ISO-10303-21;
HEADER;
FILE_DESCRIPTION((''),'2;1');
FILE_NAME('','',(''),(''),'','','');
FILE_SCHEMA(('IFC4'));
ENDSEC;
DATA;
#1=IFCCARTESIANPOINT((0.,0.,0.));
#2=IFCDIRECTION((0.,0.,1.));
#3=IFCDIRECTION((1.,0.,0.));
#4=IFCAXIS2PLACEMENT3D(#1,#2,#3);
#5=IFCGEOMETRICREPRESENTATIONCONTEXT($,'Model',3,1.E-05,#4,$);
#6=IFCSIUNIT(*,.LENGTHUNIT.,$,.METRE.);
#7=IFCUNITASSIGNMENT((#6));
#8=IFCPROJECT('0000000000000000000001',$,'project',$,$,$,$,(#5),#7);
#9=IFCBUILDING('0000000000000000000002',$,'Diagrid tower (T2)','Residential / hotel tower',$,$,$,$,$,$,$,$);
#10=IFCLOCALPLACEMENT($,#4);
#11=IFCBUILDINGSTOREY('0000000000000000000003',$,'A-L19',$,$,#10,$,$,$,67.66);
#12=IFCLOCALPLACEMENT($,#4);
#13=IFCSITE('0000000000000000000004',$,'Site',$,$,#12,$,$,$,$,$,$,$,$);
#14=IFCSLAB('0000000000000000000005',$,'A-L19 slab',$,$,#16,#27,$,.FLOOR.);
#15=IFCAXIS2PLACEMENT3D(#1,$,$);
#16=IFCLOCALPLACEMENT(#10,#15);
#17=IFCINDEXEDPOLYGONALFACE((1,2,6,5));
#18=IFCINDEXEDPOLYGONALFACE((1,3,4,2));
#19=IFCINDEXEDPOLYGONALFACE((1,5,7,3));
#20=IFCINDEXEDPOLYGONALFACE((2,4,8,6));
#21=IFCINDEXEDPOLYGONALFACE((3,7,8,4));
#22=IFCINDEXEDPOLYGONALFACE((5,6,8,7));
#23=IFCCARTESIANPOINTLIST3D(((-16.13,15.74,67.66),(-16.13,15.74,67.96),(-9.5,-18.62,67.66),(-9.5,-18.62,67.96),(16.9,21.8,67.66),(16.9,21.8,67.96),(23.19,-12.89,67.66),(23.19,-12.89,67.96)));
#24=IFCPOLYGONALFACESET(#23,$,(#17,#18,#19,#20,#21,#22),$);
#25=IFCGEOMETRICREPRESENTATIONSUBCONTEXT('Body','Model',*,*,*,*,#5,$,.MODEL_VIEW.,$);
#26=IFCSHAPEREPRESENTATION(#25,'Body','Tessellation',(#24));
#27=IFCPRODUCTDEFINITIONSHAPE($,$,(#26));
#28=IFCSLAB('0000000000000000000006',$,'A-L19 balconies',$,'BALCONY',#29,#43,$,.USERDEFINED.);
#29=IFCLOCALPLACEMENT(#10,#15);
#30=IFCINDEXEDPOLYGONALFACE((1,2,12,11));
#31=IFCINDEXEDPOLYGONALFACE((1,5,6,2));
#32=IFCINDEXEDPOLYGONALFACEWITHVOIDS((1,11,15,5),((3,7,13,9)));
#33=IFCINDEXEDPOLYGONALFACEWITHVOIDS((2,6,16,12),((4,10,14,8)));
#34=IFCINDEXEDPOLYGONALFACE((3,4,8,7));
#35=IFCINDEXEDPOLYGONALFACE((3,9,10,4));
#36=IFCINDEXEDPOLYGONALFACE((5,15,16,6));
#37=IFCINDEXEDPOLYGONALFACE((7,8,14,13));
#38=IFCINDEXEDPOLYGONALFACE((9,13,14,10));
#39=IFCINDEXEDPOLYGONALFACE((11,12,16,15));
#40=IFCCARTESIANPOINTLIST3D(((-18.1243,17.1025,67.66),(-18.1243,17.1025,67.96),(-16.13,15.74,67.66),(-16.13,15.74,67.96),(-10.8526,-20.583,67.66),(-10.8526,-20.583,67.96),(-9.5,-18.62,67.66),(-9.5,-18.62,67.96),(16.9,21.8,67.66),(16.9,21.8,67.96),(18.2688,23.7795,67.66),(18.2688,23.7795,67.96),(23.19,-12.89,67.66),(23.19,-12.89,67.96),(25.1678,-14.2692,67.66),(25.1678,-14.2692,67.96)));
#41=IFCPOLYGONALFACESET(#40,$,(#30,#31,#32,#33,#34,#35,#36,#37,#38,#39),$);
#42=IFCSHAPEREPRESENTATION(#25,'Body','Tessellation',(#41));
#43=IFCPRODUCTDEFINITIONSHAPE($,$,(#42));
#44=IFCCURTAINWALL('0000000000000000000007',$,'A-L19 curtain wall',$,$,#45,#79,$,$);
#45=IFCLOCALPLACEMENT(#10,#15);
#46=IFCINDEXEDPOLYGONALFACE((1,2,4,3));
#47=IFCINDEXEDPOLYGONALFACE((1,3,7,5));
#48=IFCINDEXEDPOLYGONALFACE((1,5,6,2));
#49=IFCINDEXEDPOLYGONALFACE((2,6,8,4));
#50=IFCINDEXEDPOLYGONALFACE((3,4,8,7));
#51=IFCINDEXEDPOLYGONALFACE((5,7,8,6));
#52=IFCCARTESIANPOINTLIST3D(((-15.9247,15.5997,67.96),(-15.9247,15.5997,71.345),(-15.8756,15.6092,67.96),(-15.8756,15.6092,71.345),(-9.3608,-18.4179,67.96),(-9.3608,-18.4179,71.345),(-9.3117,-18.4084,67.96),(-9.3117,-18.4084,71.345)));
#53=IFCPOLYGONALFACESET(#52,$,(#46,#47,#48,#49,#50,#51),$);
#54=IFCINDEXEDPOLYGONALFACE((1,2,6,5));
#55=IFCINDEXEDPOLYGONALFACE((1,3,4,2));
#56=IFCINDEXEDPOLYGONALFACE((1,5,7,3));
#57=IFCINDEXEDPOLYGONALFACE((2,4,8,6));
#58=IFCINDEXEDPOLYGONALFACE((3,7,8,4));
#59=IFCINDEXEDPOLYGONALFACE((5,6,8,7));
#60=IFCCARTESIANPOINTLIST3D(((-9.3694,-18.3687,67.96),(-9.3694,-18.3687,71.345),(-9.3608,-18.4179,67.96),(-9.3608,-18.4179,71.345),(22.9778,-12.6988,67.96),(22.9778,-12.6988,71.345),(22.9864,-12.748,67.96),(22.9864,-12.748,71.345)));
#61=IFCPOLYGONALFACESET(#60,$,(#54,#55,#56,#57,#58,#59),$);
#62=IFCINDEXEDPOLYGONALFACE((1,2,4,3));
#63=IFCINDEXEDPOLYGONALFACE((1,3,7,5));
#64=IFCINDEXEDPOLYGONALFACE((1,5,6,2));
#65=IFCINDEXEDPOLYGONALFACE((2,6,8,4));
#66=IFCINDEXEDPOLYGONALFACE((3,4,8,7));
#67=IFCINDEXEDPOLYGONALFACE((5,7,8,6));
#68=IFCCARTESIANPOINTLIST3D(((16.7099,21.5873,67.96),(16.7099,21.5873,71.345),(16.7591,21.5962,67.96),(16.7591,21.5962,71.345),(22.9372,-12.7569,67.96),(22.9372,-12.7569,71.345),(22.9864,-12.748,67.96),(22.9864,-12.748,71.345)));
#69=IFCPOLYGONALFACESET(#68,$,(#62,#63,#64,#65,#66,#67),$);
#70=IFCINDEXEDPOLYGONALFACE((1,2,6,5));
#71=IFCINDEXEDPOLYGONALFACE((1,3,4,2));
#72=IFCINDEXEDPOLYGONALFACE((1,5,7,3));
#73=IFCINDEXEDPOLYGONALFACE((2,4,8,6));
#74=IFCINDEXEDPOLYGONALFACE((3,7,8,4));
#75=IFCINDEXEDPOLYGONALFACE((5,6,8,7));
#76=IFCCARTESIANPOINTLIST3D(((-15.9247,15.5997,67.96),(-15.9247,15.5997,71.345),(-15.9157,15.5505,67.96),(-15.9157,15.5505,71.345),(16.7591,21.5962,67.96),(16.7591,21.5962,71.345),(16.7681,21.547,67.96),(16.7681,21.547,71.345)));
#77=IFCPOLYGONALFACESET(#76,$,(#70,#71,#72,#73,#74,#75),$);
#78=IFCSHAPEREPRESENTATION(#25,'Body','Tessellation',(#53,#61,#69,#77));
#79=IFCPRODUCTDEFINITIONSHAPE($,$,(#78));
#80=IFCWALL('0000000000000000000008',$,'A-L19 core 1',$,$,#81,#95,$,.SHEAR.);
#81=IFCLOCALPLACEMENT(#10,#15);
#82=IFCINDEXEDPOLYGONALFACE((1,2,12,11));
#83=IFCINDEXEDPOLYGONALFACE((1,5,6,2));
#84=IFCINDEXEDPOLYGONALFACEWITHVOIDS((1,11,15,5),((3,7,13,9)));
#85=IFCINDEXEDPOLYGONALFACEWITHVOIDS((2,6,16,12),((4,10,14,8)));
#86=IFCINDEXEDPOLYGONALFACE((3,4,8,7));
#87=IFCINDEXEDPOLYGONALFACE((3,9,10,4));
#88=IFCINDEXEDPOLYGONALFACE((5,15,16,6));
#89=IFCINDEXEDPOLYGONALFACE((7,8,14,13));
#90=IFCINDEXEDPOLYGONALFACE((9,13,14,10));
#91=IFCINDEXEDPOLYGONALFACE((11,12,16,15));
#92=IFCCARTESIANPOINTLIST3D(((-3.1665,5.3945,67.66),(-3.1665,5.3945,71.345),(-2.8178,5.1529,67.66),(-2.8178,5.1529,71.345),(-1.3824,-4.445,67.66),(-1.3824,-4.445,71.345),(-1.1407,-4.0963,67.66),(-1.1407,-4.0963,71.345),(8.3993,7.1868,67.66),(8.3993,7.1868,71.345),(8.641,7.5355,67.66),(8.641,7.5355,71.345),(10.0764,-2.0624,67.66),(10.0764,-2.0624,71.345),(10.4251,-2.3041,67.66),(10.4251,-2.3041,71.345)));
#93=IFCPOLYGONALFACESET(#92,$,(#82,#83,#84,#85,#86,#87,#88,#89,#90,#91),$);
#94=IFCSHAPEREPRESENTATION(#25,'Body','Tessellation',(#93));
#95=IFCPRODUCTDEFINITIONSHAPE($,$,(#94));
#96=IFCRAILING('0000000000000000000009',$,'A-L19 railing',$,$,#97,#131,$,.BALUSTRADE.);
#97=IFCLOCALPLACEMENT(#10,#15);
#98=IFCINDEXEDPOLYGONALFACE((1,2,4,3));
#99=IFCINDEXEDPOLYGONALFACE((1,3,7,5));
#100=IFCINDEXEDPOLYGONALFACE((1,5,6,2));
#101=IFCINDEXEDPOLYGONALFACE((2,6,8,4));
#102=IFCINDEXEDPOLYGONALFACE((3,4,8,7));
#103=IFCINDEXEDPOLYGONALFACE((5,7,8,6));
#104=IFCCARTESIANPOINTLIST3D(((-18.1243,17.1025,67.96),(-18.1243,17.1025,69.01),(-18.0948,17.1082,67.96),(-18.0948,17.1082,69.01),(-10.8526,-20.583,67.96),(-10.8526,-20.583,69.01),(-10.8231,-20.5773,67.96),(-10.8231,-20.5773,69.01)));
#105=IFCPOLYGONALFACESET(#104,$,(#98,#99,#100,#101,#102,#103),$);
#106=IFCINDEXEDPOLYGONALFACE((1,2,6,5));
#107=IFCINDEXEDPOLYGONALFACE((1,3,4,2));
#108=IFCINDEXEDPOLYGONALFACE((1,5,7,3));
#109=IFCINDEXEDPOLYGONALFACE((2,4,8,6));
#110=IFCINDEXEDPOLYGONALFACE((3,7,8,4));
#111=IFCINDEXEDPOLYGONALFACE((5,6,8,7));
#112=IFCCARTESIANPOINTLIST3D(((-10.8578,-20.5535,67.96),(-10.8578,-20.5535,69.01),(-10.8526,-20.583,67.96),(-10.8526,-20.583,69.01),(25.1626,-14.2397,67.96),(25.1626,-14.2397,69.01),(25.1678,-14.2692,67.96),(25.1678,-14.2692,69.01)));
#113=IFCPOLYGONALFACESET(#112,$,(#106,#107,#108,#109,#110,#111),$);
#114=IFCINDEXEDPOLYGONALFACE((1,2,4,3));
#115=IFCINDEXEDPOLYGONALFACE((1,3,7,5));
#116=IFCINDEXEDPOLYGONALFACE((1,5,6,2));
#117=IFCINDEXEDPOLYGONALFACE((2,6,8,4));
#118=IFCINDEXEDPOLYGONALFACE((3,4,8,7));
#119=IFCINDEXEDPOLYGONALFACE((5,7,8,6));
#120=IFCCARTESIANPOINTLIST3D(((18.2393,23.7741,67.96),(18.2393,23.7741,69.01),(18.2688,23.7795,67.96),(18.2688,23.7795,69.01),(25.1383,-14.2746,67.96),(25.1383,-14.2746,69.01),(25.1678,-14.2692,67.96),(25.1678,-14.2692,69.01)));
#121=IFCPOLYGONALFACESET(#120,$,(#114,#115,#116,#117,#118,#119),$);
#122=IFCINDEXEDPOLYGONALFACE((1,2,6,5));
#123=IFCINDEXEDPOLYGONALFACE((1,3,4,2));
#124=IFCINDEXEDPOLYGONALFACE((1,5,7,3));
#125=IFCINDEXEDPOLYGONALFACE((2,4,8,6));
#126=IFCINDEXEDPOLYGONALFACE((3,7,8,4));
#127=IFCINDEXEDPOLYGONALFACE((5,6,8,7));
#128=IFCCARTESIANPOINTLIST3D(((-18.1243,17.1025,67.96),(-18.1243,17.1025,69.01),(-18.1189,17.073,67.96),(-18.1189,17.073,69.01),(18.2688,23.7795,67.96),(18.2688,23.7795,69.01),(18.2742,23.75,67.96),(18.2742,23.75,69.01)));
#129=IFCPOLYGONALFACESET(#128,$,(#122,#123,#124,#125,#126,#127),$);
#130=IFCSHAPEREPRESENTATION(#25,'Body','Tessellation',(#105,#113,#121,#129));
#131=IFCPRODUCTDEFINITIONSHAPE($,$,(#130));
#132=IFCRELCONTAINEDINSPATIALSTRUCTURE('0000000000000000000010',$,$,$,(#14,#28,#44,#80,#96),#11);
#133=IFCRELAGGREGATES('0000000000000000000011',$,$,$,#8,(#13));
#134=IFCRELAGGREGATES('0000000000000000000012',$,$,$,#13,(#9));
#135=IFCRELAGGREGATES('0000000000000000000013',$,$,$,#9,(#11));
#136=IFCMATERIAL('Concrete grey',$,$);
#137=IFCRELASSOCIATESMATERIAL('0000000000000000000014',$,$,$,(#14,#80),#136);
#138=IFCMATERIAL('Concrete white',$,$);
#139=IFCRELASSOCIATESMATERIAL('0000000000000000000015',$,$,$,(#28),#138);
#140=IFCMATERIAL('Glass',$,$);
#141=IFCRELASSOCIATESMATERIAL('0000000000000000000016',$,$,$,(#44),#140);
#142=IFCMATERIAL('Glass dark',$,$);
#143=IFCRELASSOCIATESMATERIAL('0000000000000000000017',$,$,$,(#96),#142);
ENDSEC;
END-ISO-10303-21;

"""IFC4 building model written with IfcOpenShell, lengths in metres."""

from ifc_helpers import new_model, si_unit, frame, origin_with_axes, place, context, subcontext, project, spatial, polyline, outline, extrude, material, element, save


model = new_model("IFC4")

# Units and contexts
model_context = context("Model", 3, precision=1e-05, world=origin_with_axes())
body_context = subcontext(model_context, "Body", "Model", "MODEL_VIEW")
ifc_project = project(units=[si_unit("LENGTHUNIT", "METRE")], contexts=[model_context])

# Site, building, storey
site_placement = place(None, origin_with_axes())
site = spatial("IfcSite", under=ifc_project, at=site_placement, Name="Site")
building = spatial("IfcBuilding", under=site, Name="Diagrid tower (T2)", Description="Residential / hotel tower")
storey_placement = place(None, origin_with_axes())
storey = spatial("IfcBuildingStorey", under=building, at=storey_placement, Name="A-L19", Elevation=67.66)

# Slabs
ifc_material_1 = material(Name="Concrete grey")
slab_1_placement = place(storey_placement, origin_with_axes())
element("IfcSlab", 1, at=slab_1_placement, inside=storey, material=ifc_material_1, Name="A-L19 slab", PredefinedType="FLOOR", context=body_context, shape_type="SweptSolid", body=[
    extrude(outline(polyline([(-16.13, 15.74), (-9.5, -18.62), (23.19, -12.89), (16.9, 21.8), (-16.13, 15.74)])), frame((0.0, 0.0, 67.66), z_axis=(0.0, 0.0, 1.0), x_axis=(1.0, 0.0, 0.0)), (0.0, 0.0, 1.0), 0.3),
])
ifc_material_2 = material(Name="Concrete white")
slab_2_placement = place(storey_placement, origin_with_axes())
element("IfcSlab", 2, at=slab_2_placement, inside=storey, material=ifc_material_2, Name="A-L19 balconies", ObjectType="BALCONY", PredefinedType="USERDEFINED", context=body_context, shape_type="SweptSolid", body=[
    extrude(outline(polyline([(-18.1243, 17.1025), (-10.8526, -20.583), (25.1678, -14.2692), (18.2688, 23.7795), (-18.1243, 17.1025)]), holes=[polyline([(-16.13, 15.74), (-9.5, -18.62), (23.19, -12.89), (16.9, 21.8), (-16.13, 15.74)])]), frame((0.0, 0.0, 67.66), z_axis=(0.0, 0.0, 1.0), x_axis=(1.0, 0.0, 0.0)), (0.0, 0.0, 1.0), 0.3),
])

# Curtain wall
ifc_material_3 = material(Name="Glass")
curtain_wall_placement = place(storey_placement, origin_with_axes())
element("IfcCurtainWall", 3, at=curtain_wall_placement, inside=storey, material=ifc_material_3, Name="A-L19 curtain wall", context=body_context, shape_type="SweptSolid", body=[
    extrude(outline(polyline([(-15.9247, 15.5997), (-9.3608, -18.4179), (-9.3117, -18.4084), (-15.8756, 15.6092), (-15.9247, 15.5997)])), frame((0.0, 0.0, 67.96), z_axis=(0.0, 0.0, 1.0), x_axis=(1.0, 0.0, 0.0)), (0.0, 0.0, 1.0), 3.385),
    extrude(outline(polyline([(-9.3608, -18.4179), (22.9864, -12.748), (22.9778, -12.6988), (-9.3694, -18.3687), (-9.3608, -18.4179)])), frame((0.0, 0.0, 67.96), z_axis=(0.0, 0.0, 1.0), x_axis=(1.0, 0.0, 0.0)), (0.0, 0.0, 1.0), 3.385),
    extrude(outline(polyline([(22.9864, -12.748), (16.7591, 21.5962), (16.7099, 21.5873), (22.9372, -12.7569), (22.9864, -12.748)])), frame((0.0, 0.0, 67.96), z_axis=(0.0, 0.0, 1.0), x_axis=(1.0, 0.0, 0.0)), (0.0, 0.0, 1.0), 3.385),
    extrude(outline(polyline([(16.7591, 21.5962), (-15.9247, 15.5997), (-15.9157, 15.5505), (16.7681, 21.547), (16.7591, 21.5962)])), frame((0.0, 0.0, 67.96), z_axis=(0.0, 0.0, 1.0), x_axis=(1.0, 0.0, 0.0)), (0.0, 0.0, 1.0), 3.385),
])

# Wall
wall_placement = place(storey_placement, origin_with_axes())
element("IfcWall", 4, at=wall_placement, inside=storey, material=ifc_material_1, Name="A-L19 core 1", PredefinedType="SHEAR", context=body_context, shape_type="SweptSolid", body=[
    extrude(outline(polyline([(10.4251, -2.3041), (8.641, 7.5355), (-3.1665, 5.3945), (-1.3824, -4.445), (10.4251, -2.3041)]), holes=[polyline([(10.0764, -2.0624), (8.3993, 7.1868), (-2.8178, 5.1529), (-1.1407, -4.0963), (10.0764, -2.0624)])]), frame((0.0, 0.0, 67.66), z_axis=(0.0, 0.0, 1.0), x_axis=(1.0, 0.0, 0.0)), (0.0, 0.0, 1.0), 3.685),
])

# Railing
ifc_material_4 = material(Name="Glass dark")
railing_placement = place(storey_placement, origin_with_axes())
element("IfcRailing", 5, at=railing_placement, inside=storey, material=ifc_material_4, Name="A-L19 railing", PredefinedType="BALUSTRADE", context=body_context, shape_type="SweptSolid", body=[
    extrude(outline(polyline([(-18.1243, 17.1025), (-10.8526, -20.583), (-10.8231, -20.5773), (-18.0948, 17.1082), (-18.1243, 17.1025)])), frame((0.0, 0.0, 67.96), z_axis=(0.0, 0.0, 1.0), x_axis=(1.0, 0.0, 0.0)), (0.0, 0.0, 1.0), 1.05),
    extrude(outline(polyline([(-10.8526, -20.583), (25.1678, -14.2692), (25.1626, -14.2397), (-10.8578, -20.5535), (-10.8526, -20.583)])), frame((0.0, 0.0, 67.96), z_axis=(0.0, 0.0, 1.0), x_axis=(1.0, 0.0, 0.0)), (0.0, 0.0, 1.0), 1.05),
    extrude(outline(polyline([(25.1678, -14.2692), (18.2688, 23.7795), (18.2393, 23.7741), (25.1383, -14.2746), (25.1678, -14.2692)])), frame((0.0, 0.0, 67.96), z_axis=(0.0, 0.0, 1.0), x_axis=(1.0, 0.0, 0.0)), (0.0, 0.0, 1.0), 1.05),
    extrude(outline(polyline([(18.2688, 23.7795), (-18.1243, 17.1025), (-18.1189, 17.073), (18.2742, 23.75), (18.2688, 23.7795)])), frame((0.0, 0.0, 67.96), z_axis=(0.0, 0.0, 1.0), x_axis=(1.0, 0.0, 0.0)), (0.0, 0.0, 1.0), 1.05),
])

save(model, "model.ifc")
